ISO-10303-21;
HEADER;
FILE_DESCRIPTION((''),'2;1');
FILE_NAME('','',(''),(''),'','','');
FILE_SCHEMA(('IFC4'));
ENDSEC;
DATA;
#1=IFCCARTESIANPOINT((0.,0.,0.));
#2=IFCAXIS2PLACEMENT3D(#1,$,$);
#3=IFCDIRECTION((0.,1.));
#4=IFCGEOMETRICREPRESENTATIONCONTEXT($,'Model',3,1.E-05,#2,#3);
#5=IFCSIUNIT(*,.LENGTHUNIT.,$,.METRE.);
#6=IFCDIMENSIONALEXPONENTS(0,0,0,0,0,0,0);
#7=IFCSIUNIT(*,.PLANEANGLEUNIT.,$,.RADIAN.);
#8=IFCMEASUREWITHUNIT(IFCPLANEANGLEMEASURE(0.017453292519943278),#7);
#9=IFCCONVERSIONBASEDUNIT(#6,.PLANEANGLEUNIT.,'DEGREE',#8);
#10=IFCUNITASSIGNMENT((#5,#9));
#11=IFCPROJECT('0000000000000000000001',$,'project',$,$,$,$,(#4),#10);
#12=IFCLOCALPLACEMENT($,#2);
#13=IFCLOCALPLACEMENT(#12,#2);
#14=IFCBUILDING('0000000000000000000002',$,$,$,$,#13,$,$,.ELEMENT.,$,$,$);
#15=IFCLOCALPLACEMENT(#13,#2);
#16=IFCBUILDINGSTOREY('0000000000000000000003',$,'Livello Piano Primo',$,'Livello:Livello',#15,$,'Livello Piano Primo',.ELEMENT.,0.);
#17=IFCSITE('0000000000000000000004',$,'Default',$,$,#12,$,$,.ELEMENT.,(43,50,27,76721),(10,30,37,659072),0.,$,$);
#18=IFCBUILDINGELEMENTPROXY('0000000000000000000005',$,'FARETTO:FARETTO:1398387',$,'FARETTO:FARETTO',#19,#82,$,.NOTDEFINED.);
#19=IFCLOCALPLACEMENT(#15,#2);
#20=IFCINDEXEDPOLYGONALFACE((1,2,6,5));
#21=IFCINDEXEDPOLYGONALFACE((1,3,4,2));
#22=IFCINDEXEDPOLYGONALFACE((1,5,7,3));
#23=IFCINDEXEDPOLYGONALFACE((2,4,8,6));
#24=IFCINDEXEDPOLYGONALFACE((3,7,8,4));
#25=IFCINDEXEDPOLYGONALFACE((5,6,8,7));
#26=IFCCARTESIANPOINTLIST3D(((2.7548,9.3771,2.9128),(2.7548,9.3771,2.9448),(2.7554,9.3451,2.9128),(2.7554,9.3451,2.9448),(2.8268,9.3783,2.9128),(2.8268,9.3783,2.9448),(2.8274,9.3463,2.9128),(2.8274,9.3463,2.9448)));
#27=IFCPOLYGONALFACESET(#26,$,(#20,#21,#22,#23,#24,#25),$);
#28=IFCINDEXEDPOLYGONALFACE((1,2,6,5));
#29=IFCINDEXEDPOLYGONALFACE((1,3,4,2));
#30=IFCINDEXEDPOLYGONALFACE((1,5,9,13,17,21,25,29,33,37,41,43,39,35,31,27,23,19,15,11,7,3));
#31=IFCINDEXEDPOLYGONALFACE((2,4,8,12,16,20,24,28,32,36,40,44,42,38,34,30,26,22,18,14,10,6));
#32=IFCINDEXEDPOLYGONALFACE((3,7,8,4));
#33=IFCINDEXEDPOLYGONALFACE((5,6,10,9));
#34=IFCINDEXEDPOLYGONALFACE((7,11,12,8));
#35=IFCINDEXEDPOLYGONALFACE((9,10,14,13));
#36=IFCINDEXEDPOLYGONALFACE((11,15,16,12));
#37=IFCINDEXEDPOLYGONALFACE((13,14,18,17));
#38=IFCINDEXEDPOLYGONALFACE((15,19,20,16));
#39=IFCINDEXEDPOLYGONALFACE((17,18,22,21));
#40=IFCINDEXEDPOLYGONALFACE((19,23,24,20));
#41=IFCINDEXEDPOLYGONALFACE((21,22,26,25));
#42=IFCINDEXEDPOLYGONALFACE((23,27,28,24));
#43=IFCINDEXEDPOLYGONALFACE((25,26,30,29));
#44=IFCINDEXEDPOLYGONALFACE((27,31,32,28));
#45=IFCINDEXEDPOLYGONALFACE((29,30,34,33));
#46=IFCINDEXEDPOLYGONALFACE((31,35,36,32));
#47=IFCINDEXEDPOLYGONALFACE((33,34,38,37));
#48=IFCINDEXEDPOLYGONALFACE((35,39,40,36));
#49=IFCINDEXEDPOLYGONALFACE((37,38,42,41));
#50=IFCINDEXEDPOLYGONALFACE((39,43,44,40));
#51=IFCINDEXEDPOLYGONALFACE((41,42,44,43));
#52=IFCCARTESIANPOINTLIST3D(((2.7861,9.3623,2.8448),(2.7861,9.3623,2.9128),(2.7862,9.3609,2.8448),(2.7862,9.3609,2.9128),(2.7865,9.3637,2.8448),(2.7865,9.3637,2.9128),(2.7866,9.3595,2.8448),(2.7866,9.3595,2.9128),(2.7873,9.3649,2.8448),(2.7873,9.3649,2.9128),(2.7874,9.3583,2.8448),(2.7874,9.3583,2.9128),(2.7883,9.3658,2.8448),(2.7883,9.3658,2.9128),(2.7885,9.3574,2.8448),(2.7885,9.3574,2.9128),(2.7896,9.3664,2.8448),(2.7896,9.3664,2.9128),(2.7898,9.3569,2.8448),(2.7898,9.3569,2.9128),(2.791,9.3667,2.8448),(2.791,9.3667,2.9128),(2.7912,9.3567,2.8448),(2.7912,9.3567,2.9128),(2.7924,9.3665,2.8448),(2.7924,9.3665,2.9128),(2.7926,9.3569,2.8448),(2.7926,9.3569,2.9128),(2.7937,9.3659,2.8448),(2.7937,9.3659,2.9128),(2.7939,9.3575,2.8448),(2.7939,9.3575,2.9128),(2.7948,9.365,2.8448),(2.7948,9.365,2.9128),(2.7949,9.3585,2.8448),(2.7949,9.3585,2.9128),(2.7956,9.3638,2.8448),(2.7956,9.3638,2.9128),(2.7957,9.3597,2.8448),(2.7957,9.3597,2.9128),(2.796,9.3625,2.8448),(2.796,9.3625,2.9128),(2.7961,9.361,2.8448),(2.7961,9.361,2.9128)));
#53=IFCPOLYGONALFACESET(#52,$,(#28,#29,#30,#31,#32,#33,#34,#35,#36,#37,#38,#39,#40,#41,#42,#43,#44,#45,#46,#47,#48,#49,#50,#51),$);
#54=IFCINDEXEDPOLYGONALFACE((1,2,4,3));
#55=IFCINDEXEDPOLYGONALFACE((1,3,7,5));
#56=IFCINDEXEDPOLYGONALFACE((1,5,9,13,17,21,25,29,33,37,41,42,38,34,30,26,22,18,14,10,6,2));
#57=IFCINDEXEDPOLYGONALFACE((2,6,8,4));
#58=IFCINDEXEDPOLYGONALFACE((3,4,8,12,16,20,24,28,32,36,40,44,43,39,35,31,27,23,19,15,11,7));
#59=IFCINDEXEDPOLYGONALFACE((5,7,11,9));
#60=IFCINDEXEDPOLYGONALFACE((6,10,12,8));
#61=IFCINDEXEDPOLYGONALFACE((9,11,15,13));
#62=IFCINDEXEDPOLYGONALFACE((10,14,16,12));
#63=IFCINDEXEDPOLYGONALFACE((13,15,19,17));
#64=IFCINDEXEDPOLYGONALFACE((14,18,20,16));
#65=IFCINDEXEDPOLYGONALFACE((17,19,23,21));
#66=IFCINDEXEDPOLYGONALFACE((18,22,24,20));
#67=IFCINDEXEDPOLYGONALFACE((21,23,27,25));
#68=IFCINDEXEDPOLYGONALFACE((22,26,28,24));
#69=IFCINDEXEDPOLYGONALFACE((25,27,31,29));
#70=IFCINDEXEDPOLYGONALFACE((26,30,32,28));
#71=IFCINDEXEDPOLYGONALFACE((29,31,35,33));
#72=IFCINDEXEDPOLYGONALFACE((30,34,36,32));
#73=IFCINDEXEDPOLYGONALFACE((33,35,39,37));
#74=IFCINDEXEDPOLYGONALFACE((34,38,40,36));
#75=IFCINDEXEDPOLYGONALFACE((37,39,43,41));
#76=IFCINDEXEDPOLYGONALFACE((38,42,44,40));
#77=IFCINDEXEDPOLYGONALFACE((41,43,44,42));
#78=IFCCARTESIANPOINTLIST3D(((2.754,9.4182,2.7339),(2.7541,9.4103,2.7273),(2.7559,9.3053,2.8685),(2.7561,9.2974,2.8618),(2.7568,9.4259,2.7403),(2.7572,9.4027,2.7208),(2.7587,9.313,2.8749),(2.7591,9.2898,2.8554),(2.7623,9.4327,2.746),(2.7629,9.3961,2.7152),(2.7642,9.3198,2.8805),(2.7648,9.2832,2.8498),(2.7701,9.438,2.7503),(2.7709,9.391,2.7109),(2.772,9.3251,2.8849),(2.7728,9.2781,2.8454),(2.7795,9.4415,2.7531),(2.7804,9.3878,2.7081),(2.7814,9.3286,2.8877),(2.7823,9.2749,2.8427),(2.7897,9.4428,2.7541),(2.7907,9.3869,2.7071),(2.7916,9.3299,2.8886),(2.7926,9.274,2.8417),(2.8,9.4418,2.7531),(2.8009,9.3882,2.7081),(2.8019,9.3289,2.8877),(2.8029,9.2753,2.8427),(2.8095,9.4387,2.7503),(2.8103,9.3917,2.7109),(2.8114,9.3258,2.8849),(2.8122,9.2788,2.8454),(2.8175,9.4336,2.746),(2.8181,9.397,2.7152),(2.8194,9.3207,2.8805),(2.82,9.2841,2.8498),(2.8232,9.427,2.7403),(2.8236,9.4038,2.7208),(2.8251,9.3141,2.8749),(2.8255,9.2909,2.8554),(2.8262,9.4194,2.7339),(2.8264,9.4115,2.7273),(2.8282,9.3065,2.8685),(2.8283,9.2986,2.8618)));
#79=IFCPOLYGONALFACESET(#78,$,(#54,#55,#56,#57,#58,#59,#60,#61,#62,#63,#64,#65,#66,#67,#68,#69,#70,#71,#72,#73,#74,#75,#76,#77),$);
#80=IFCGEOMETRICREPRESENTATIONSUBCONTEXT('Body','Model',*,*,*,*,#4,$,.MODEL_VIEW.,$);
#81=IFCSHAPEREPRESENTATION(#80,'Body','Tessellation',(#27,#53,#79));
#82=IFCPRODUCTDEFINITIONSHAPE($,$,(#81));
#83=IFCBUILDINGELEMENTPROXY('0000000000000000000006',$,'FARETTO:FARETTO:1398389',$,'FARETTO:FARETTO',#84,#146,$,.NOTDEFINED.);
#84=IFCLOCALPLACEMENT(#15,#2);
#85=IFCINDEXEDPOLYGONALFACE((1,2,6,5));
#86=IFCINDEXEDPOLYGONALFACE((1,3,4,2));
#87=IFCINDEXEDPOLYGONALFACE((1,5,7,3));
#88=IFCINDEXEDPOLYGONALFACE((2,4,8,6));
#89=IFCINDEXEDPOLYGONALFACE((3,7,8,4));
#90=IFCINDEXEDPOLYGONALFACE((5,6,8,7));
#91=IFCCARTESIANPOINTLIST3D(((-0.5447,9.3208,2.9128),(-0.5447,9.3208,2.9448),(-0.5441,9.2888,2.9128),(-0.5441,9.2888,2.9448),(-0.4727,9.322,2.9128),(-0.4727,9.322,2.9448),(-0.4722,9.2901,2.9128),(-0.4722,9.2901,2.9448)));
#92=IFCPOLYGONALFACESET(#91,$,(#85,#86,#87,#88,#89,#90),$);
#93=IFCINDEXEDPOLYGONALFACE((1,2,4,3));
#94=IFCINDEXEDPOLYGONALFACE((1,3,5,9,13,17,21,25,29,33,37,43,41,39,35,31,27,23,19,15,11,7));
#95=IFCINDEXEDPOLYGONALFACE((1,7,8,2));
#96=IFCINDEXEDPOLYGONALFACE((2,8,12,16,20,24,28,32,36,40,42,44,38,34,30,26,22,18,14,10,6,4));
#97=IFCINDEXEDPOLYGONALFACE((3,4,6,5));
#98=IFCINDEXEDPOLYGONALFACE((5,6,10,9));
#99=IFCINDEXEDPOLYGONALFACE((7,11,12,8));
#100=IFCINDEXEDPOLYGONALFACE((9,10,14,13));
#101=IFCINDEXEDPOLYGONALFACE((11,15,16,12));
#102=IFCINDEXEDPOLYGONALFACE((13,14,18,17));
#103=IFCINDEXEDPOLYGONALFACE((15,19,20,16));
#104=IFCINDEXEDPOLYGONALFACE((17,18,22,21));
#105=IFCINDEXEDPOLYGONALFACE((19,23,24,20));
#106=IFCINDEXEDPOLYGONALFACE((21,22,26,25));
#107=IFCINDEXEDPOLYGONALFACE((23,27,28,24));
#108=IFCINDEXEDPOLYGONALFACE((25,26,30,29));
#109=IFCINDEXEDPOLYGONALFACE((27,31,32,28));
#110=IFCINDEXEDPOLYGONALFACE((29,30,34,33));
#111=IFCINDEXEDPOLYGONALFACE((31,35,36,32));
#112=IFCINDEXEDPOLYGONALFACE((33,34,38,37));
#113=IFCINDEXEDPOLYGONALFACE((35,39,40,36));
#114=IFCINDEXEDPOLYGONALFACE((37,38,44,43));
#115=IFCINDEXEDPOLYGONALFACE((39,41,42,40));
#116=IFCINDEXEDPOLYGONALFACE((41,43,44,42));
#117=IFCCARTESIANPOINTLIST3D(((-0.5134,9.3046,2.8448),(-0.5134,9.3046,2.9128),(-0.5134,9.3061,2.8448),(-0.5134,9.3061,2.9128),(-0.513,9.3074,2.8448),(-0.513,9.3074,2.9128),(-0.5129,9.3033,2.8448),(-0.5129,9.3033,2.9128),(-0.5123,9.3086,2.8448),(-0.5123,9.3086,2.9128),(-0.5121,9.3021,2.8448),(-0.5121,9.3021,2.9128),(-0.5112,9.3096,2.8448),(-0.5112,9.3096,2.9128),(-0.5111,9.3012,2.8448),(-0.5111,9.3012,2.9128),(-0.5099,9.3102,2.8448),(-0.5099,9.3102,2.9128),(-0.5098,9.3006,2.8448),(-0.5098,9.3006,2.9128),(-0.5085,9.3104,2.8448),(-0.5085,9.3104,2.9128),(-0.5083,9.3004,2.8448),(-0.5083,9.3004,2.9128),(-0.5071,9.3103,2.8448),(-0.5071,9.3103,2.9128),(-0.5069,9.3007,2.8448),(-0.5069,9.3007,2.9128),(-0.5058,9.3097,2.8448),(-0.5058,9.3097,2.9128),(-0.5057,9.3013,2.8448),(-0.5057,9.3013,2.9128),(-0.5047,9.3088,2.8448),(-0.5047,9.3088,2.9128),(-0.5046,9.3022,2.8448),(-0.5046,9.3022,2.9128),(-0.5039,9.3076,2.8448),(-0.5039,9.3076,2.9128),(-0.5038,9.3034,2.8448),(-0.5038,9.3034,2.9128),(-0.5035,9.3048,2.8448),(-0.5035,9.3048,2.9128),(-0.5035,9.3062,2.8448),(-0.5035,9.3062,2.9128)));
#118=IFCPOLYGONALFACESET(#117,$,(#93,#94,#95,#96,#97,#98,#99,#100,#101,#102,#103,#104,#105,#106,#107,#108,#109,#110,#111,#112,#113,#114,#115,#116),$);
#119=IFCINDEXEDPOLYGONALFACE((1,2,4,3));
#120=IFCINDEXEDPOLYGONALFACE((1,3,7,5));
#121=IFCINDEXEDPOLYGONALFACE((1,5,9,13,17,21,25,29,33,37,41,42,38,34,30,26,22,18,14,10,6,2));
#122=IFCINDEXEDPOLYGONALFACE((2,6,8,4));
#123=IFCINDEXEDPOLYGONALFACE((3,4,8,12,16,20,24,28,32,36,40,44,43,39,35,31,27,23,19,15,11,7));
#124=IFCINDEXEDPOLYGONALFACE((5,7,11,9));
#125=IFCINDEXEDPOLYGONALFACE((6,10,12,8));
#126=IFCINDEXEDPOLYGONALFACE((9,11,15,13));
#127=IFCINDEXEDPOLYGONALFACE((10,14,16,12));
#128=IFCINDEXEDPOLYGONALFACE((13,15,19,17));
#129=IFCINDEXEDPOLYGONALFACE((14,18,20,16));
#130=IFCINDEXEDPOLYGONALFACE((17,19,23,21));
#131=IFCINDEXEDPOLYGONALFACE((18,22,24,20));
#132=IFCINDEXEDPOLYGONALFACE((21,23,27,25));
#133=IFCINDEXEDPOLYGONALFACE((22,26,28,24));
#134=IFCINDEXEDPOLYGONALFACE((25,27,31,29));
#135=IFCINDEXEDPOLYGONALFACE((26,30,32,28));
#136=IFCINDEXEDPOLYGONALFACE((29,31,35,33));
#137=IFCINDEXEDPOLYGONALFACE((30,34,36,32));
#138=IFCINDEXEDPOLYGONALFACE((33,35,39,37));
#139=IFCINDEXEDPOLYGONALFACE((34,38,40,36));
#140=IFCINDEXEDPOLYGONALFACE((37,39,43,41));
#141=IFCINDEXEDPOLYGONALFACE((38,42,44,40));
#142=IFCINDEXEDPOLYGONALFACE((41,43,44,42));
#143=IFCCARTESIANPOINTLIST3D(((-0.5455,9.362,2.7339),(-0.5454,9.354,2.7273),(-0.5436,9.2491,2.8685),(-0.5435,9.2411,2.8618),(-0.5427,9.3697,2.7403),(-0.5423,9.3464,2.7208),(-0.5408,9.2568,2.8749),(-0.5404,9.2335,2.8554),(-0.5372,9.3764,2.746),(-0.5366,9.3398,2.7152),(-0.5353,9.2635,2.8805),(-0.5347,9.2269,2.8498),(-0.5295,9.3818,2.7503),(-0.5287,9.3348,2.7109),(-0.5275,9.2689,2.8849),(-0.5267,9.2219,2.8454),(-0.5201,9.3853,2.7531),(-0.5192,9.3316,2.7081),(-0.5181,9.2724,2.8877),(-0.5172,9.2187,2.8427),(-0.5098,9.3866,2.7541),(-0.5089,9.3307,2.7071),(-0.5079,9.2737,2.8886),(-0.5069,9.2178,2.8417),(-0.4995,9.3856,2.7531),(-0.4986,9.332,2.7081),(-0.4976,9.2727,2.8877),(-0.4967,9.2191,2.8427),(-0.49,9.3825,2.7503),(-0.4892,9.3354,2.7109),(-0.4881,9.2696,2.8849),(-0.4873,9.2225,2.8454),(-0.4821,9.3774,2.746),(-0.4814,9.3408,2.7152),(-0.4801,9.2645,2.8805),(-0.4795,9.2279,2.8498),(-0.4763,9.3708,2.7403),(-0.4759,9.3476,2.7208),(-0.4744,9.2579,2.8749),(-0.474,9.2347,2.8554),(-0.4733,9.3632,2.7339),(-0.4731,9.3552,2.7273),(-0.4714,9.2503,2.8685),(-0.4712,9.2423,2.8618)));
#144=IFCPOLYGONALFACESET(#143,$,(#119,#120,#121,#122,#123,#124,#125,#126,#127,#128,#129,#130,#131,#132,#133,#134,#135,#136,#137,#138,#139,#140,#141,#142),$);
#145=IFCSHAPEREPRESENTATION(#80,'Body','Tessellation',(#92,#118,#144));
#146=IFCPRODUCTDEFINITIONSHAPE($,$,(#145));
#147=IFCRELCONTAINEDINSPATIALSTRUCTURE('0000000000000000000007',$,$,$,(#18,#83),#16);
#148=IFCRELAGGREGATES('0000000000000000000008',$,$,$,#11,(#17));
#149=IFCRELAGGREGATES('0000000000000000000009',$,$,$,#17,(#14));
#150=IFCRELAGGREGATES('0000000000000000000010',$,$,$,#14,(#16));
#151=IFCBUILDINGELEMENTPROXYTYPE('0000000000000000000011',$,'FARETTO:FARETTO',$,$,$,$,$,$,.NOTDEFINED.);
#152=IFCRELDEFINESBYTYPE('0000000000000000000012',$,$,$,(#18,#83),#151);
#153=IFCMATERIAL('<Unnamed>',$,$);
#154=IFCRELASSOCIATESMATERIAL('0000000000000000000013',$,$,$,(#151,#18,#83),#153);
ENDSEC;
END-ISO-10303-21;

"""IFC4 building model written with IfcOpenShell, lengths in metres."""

from ifc_helpers import new_model, entity, si_unit, converted_unit, direction, frame, origin, place, context, subcontext, project, spatial, arc, indexed_curve, outline, extrude, source, transform, mapped, material, type_object, type_shapes, element, save


model = new_model("IFC4")

# Units and contexts
model_context = context("Model", 3, precision=1e-05, world=origin(), true_north=direction((0.0, 1.0)))
body_context = subcontext(model_context, "Body", "Model", "MODEL_VIEW")
ifc_project = project(units=[si_unit("LENGTHUNIT", "METRE"), converted_unit("PLANEANGLEUNIT", "DEGREE", entity("IfcPlaneAngleMeasure", 0.017453292519943278), si_unit("PLANEANGLEUNIT", "RADIAN"), dimensions=[0, 0, 0, 0, 0, 0, 0])], contexts=[model_context])

# Site, building, storey
site_placement = place(None, origin())
site = spatial("IfcSite", under=ifc_project, at=site_placement, Name="Default", CompositionType="ELEMENT", RefLatitude=(43, 50, 27, 76721), RefLongitude=(10, 30, 37, 659072), RefElevation=0.0)
building_placement = place(site_placement, origin())
building = spatial("IfcBuilding", under=site, at=building_placement, CompositionType="ELEMENT")
storey_placement = place(building_placement, origin())
storey = spatial("IfcBuildingStorey", under=building, at=storey_placement, Name="Livello Piano Primo", ObjectType="Livello:Livello", LongName="Livello Piano Primo", CompositionType="ELEMENT", Elevation=0.0)

# Building element proxies
ifc_material_1 = material(Name="<Unnamed>")
building_element_proxy_type_1 = type_object("IfcBuildingElementProxyType", Name="FARETTO:FARETTO", PredefinedType="NOTDEFINED", material=ifc_material_1)
shared_shape_1 = source(origin(), body_context, "Body", "SweptSolid", [
    extrude(outline(indexed_curve([(-0.016, -0.036), (0.016, -0.036), (0.016, 0.036), (-0.016, 0.036), (-0.016, -0.036)], self_intersect=False)), frame((0.032, 0.0, 0.0), z_axis=(0.0, 0.0, 1.0), x_axis=(-1.0, 0.0, 0.0)), (0.0, 0.0, 1.0), 0.032),
    extrude(outline(indexed_curve([(-0.005, 0.0), (0.0, -0.005), (0.005, 0.0), (0.0, 0.005)], segments=[arc(1, 2, 3), arc(3, 4, 1)], self_intersect=False)), frame((0.032, 0.0, 0.032)), (0.0, 0.0, 1.0), 0.068),
    extrude(outline(indexed_curve([(-0.0365, 0.0), (0.0, -0.0365), (0.0365, 0.0), (0.0, 0.0365)], segments=[arc(1, 2, 3), arc(3, 4, 1)], self_intersect=False)), frame((-0.0277, 0.0, 0.0796), z_axis=(0.642788, 0.0, 0.766044), x_axis=(0.766044, 0.0, -0.642788)), (0.0, 0.0, 1.0), 0.1757),
])
type_shapes(building_element_proxy_type_1, [shared_shape_1])
for number, where, z_axis, x_axis, name in (
    (1, (2.7916, 9.3297, 2.9448), (0.0, 0.0, -1.0), (-0.017041, 0.999855, 0.0), "FARETTO:FARETTO:1398387"),
    (2, (-0.5079, 9.2734, 2.9448), (0.0, 0.0, -1.0), (-0.017041, 0.999855, 0.0), "FARETTO:FARETTO:1398389"),
):
    element("IfcBuildingElementProxy", number, at=place(storey_placement, frame(where, z_axis=z_axis, x_axis=x_axis)), inside=storey, type_object=building_element_proxy_type_1, material=ifc_material_1, Name=name, ObjectType="FARETTO:FARETTO", PredefinedType="NOTDEFINED", context=body_context, shape_type="MappedRepresentation", body=[
        mapped(shared_shape_1, transform((0.0, 0.0, 0.0), scale=1.0)),
    ])

save(model, "model.ifc")
